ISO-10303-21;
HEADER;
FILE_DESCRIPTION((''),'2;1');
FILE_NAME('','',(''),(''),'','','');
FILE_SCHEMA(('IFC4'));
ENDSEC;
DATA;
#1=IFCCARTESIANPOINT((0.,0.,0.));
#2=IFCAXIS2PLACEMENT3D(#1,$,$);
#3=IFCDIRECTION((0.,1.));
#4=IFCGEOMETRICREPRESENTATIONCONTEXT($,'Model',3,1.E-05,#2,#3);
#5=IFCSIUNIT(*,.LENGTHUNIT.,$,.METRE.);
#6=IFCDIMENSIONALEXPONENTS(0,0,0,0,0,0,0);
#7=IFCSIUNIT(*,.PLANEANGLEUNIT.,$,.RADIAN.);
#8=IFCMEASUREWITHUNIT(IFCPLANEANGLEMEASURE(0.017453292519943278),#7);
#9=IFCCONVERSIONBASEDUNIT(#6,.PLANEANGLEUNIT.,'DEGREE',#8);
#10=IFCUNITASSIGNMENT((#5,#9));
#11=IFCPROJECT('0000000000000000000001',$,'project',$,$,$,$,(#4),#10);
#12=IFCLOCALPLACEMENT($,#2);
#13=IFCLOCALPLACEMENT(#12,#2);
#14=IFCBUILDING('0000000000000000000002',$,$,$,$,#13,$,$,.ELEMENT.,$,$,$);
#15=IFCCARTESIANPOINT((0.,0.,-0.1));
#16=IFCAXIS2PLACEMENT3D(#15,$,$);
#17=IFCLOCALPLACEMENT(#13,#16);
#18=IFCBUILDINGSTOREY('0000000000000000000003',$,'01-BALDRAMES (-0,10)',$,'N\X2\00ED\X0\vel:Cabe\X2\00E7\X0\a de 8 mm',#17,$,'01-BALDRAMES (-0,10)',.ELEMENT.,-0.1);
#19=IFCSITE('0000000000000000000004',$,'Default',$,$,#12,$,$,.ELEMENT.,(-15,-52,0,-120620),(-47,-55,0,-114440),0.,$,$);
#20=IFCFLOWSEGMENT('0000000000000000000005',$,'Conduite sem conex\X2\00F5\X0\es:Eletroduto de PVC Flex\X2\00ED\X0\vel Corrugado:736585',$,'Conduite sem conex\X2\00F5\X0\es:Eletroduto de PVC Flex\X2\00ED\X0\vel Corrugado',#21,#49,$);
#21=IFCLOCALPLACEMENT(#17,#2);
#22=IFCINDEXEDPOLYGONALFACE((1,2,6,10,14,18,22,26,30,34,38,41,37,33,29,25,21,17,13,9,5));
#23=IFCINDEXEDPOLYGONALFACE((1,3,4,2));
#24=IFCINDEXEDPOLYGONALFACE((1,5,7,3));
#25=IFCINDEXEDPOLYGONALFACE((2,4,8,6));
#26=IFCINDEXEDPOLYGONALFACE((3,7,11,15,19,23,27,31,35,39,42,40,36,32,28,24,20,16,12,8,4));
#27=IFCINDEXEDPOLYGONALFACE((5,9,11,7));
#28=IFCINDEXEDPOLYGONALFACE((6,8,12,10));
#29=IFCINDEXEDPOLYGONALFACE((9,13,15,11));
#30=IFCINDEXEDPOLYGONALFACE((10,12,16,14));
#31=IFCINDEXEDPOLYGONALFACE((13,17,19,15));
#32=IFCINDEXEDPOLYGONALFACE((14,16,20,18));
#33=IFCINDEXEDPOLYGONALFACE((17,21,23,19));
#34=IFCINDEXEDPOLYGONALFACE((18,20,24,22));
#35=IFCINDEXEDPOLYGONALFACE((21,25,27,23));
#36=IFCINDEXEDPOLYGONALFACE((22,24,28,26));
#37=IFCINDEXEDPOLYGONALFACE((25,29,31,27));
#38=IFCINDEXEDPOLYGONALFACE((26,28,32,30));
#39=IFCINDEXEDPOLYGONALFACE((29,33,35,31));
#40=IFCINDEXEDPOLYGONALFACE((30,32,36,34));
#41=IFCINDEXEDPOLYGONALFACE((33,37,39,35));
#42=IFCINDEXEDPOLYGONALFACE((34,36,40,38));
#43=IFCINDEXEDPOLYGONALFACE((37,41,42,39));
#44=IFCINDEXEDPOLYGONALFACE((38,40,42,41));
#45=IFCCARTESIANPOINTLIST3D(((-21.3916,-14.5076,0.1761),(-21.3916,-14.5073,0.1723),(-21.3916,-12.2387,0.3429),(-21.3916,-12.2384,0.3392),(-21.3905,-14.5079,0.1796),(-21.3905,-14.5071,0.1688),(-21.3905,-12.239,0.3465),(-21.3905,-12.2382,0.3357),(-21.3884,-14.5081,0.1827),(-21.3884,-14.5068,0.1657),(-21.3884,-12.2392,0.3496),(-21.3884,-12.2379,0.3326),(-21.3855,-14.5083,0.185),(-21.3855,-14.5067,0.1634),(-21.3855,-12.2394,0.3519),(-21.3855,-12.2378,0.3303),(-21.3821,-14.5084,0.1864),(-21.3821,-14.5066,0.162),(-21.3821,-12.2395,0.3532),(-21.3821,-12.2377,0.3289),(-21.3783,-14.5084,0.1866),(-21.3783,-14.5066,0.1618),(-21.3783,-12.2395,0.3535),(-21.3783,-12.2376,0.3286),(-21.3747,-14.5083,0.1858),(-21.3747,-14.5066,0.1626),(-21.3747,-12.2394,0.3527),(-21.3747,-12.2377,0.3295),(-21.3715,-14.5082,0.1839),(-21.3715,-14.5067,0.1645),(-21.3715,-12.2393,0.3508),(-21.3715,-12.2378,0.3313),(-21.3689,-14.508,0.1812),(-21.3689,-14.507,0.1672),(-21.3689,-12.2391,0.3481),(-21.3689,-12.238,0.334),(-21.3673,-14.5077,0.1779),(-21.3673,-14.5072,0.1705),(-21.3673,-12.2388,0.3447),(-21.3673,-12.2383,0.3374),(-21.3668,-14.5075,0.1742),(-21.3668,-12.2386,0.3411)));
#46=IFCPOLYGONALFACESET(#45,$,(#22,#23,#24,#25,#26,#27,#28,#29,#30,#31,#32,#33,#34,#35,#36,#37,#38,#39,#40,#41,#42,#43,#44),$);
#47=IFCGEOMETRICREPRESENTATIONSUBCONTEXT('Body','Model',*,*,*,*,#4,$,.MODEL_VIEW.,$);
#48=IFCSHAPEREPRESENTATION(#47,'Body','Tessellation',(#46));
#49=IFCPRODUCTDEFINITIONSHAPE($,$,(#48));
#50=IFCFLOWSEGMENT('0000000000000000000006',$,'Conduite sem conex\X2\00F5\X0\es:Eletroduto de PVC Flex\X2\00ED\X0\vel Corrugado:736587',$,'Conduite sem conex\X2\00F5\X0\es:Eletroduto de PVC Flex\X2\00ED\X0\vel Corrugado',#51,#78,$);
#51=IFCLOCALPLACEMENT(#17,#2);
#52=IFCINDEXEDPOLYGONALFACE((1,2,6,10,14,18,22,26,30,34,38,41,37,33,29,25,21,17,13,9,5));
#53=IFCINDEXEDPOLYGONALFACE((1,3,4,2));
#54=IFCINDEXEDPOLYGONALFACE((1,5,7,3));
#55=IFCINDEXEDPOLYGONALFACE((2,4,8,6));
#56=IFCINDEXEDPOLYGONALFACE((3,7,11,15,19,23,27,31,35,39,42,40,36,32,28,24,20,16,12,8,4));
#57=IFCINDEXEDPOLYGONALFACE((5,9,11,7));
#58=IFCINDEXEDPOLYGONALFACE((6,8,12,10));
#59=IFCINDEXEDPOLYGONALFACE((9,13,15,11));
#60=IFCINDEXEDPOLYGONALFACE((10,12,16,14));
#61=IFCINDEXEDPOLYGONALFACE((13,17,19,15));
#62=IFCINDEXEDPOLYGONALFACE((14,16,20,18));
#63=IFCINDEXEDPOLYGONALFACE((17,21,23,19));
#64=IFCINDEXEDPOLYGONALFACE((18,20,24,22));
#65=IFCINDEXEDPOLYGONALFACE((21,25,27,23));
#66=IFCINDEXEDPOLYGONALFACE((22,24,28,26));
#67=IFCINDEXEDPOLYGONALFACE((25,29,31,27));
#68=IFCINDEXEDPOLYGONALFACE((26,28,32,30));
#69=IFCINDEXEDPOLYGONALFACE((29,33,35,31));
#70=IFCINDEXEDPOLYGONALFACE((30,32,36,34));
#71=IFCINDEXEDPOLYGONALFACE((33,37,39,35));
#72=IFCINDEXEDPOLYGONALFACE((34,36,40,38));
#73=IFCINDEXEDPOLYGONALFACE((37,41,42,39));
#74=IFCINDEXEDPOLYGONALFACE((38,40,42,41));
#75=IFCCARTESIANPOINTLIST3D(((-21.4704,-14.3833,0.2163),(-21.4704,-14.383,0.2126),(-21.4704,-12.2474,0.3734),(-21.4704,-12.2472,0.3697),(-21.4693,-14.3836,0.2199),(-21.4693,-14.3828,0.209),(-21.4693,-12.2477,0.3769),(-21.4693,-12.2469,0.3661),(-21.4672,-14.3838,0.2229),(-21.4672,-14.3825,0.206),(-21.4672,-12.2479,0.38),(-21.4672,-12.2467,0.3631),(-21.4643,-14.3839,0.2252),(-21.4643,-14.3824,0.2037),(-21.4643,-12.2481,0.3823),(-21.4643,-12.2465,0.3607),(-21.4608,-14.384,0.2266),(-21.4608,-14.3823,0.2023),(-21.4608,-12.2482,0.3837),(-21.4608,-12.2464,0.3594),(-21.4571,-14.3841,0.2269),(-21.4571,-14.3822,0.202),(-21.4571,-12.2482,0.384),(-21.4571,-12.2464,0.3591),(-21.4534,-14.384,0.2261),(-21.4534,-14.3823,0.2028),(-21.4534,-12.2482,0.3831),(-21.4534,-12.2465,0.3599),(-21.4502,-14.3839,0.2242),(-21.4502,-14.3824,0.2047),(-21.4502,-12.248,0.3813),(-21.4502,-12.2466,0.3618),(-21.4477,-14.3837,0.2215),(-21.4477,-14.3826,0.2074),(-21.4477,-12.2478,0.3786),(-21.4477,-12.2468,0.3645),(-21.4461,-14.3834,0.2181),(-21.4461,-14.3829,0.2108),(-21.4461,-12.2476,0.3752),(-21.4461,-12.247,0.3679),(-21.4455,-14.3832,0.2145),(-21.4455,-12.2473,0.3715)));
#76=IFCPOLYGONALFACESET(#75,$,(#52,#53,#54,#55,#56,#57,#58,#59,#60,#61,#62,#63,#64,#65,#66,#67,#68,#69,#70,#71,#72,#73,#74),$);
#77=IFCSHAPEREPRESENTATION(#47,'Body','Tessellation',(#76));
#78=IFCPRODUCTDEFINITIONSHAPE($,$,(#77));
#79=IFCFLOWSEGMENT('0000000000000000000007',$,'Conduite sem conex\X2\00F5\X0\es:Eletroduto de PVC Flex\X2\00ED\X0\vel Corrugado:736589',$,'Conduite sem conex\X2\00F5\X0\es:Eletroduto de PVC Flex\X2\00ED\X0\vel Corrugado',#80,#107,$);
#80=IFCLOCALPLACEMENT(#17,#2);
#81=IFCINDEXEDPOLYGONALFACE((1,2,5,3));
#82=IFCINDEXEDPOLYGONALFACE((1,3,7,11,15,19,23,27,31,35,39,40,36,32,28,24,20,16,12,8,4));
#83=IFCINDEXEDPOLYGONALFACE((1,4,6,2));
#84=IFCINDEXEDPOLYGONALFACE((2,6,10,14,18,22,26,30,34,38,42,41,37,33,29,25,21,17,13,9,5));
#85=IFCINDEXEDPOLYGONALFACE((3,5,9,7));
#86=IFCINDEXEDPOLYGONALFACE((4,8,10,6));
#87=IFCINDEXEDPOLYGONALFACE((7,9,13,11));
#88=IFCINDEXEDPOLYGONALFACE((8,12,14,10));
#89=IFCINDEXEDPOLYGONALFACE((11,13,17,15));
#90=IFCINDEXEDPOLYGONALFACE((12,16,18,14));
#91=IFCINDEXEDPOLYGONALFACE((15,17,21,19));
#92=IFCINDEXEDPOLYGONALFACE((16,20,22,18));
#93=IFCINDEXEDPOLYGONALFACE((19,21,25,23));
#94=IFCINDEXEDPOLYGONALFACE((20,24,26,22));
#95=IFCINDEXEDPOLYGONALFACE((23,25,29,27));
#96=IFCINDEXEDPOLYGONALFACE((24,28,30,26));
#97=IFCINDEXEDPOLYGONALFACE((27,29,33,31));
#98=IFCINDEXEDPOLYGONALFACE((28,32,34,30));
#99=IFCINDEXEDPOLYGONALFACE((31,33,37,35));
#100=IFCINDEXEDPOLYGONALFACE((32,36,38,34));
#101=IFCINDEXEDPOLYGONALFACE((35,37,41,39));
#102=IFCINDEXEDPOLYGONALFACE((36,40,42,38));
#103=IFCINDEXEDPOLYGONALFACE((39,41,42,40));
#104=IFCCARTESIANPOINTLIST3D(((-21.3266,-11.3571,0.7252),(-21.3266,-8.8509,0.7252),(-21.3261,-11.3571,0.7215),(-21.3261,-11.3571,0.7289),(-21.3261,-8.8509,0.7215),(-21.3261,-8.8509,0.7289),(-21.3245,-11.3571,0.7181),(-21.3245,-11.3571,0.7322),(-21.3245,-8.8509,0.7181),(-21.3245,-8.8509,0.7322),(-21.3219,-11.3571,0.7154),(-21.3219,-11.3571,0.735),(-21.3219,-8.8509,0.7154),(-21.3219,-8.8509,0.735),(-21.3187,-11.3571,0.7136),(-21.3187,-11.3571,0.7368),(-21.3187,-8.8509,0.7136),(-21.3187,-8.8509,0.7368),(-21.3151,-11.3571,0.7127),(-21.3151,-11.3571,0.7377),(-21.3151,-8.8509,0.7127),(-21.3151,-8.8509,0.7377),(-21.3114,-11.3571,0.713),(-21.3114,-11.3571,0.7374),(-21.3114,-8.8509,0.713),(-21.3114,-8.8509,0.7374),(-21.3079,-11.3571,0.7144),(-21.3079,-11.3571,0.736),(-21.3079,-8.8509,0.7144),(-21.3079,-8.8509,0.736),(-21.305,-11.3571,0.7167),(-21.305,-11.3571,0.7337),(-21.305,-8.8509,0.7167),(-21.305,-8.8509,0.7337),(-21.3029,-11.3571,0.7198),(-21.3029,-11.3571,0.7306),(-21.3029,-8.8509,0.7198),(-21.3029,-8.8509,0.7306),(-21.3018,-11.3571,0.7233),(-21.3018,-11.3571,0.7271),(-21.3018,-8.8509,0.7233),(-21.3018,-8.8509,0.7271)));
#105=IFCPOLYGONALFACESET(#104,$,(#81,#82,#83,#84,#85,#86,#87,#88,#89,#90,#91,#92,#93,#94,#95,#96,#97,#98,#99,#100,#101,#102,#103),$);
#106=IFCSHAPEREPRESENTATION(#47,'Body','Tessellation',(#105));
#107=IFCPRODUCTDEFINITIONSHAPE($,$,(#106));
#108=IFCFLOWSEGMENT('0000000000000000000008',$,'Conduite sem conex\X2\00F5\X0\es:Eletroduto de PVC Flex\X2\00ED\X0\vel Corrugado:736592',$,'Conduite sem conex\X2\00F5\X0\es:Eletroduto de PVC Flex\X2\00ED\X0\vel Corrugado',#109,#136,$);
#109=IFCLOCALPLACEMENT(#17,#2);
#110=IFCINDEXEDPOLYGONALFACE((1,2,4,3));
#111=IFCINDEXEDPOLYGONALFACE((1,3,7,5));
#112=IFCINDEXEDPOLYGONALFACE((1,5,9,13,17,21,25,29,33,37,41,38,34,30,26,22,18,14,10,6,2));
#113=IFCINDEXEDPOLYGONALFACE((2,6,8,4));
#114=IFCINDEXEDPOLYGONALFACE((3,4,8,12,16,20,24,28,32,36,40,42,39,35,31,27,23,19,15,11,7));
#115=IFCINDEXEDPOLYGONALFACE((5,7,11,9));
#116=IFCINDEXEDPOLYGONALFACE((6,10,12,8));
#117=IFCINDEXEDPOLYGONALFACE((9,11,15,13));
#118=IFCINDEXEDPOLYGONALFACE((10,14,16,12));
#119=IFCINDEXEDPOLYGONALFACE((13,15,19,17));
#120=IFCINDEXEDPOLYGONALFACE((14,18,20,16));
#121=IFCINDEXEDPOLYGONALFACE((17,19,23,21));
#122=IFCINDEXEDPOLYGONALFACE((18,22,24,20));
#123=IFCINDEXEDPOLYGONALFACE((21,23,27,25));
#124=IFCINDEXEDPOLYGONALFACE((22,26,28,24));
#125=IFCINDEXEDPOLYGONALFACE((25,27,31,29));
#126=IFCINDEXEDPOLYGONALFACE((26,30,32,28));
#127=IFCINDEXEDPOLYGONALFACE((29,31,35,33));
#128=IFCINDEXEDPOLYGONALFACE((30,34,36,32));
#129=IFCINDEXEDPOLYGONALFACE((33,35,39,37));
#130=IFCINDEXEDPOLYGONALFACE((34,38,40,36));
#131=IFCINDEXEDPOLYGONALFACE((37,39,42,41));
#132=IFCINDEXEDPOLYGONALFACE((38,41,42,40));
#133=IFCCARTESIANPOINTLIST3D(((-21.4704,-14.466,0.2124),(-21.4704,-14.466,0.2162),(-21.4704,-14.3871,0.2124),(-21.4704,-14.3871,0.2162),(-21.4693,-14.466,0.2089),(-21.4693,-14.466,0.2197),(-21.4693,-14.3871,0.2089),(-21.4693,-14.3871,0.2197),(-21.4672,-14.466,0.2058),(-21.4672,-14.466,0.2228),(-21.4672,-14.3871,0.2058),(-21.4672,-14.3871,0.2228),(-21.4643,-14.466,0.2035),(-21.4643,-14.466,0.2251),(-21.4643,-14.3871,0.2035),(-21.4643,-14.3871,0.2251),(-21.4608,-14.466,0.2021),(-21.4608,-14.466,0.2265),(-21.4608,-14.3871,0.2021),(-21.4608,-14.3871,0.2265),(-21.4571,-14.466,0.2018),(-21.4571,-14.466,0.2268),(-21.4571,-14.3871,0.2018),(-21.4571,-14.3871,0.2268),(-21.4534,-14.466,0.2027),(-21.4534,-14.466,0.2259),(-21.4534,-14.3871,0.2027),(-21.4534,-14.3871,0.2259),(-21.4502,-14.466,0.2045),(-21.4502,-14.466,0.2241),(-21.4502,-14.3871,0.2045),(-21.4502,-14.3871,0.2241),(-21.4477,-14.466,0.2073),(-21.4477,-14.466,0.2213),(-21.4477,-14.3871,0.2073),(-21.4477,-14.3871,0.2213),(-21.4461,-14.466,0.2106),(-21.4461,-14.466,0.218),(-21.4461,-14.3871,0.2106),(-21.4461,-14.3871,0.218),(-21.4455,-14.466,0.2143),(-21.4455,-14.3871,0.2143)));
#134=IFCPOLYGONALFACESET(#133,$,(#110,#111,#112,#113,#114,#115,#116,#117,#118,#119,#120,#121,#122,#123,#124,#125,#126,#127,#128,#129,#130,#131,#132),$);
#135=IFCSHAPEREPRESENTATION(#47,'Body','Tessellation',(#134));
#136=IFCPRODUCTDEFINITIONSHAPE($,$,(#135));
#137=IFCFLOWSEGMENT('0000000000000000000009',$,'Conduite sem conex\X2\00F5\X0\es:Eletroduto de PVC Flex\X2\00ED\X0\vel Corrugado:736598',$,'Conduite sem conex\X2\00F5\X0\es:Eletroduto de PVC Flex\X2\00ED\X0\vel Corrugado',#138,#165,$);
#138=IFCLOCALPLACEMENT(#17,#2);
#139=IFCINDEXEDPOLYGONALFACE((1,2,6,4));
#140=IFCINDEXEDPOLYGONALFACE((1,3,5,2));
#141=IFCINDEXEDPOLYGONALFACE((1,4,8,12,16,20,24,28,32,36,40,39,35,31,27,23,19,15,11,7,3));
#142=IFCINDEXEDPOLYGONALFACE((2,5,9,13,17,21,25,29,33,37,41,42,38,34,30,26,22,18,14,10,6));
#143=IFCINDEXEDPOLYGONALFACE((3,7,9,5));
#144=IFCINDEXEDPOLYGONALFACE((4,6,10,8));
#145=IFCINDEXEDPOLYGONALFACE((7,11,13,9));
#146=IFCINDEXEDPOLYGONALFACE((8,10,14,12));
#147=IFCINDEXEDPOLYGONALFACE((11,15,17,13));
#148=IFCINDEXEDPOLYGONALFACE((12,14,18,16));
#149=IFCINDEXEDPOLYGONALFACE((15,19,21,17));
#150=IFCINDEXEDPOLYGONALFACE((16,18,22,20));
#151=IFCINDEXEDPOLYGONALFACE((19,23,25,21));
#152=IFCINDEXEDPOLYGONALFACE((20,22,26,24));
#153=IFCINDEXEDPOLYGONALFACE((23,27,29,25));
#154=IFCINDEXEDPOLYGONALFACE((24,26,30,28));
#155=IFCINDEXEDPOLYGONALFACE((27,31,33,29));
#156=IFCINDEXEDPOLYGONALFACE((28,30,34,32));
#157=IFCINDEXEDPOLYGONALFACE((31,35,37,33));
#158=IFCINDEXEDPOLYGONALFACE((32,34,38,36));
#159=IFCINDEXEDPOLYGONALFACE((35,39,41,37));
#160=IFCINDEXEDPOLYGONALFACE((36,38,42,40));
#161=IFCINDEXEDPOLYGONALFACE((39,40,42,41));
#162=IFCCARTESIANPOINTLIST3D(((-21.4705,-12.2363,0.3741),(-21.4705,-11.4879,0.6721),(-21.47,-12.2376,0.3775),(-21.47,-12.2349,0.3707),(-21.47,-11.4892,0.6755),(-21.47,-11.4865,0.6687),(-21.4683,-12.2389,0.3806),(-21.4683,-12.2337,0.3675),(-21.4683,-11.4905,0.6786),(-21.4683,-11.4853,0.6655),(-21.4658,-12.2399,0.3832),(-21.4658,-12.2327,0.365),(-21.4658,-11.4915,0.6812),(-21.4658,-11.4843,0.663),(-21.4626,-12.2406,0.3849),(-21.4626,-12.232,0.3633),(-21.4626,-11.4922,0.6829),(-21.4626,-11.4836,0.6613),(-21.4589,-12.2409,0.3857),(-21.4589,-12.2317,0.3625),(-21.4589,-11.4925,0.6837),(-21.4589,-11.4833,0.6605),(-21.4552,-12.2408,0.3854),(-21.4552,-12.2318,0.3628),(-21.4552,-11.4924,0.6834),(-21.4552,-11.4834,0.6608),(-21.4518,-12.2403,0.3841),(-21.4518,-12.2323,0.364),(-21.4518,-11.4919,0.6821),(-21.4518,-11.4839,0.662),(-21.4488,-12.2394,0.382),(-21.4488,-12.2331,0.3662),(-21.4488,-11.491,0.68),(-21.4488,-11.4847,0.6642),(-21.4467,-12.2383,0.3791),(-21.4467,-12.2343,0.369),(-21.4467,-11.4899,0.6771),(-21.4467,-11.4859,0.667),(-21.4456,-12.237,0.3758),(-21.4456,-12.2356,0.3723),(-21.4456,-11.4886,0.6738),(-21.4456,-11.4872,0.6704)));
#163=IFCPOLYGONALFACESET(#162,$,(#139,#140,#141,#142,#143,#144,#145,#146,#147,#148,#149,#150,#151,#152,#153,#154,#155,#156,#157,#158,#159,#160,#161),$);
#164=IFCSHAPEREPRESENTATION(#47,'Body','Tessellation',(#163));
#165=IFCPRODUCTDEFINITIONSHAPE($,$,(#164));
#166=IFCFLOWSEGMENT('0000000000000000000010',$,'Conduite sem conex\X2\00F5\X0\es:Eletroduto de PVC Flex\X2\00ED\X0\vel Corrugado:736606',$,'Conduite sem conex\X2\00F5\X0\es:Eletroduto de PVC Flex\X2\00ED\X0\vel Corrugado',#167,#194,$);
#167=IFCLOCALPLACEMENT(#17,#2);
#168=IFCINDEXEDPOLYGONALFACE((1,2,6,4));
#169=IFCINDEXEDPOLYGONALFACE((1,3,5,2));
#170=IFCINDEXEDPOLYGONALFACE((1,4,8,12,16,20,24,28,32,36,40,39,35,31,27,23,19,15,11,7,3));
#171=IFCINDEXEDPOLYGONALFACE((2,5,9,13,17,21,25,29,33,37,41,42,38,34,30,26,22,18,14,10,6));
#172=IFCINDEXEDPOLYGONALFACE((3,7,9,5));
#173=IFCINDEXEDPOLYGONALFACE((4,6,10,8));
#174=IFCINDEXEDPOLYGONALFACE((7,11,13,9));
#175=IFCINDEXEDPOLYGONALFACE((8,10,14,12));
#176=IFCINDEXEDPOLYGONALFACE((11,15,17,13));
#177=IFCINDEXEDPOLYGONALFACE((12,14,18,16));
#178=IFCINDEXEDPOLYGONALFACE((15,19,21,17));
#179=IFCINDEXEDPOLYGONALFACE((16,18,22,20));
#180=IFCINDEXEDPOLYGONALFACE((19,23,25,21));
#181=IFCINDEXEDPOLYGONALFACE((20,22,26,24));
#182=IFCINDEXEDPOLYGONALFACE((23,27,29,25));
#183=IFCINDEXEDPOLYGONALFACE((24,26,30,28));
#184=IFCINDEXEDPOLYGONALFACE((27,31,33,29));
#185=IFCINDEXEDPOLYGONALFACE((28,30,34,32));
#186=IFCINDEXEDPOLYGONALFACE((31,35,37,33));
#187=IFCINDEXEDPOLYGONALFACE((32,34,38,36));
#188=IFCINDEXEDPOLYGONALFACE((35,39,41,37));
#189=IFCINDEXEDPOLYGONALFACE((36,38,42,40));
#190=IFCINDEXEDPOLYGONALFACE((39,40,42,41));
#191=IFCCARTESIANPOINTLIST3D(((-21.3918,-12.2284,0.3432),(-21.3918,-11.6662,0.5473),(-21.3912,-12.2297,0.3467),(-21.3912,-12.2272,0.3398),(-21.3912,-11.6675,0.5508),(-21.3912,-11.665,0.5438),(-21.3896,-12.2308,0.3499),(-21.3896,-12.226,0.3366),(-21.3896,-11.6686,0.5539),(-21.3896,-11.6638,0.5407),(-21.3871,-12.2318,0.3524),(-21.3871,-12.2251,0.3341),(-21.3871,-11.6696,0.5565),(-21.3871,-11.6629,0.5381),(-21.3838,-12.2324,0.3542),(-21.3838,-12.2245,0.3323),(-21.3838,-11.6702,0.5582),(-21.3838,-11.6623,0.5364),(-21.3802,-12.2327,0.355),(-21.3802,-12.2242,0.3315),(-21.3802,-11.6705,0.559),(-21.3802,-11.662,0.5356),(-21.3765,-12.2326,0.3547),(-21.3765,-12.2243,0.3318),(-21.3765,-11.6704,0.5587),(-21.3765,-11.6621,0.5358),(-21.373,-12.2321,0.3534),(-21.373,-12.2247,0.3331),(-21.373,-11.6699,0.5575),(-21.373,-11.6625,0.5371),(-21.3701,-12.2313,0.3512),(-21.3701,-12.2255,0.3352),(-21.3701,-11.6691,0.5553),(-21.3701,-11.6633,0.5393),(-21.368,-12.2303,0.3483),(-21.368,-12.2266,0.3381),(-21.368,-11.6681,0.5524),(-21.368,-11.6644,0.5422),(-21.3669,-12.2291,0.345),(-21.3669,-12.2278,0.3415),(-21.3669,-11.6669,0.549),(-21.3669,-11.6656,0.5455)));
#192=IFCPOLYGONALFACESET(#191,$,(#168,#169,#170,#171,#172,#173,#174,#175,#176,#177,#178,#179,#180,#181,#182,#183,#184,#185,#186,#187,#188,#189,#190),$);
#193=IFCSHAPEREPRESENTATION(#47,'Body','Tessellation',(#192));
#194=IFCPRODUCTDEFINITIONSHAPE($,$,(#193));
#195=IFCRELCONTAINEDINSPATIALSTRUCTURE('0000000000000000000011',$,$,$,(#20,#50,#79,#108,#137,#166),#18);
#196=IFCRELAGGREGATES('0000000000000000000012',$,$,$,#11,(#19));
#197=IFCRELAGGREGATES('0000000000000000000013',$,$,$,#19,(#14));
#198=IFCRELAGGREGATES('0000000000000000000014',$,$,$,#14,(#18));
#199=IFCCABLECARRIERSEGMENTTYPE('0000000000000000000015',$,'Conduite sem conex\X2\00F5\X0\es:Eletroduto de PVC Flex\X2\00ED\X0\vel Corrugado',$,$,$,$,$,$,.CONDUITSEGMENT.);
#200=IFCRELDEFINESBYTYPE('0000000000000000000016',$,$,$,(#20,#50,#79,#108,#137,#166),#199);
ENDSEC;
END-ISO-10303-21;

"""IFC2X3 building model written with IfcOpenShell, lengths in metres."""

from ifc_helpers import new_model, entity, si_unit, converted_unit, direction, frame, frame_2d, origin, place, context, subcontext, project, spatial, circle, extrude, type_object, element, save


model = new_model("IFC2X3")

# Units and contexts
model_context = context("Model", 3, precision=1e-05, world=origin(), true_north=direction((0.0, 1.0)))
body_context = subcontext(model_context, "Body", "Model", "MODEL_VIEW")
ifc_project = project(units=[si_unit("LENGTHUNIT", "METRE"), converted_unit("PLANEANGLEUNIT", "DEGREE", entity("IfcPlaneAngleMeasure", 0.017453292519943278), si_unit("PLANEANGLEUNIT", "RADIAN"), dimensions=[0, 0, 0, 0, 0, 0, 0])], contexts=[model_context])

# Site, building, storey
site_placement = place(None, origin())
site = spatial("IfcSite", under=ifc_project, at=site_placement, Name="Default", CompositionType="ELEMENT", RefLatitude=(-15, -52, 0, -120620), RefLongitude=(-47, -55, 0, -114440), RefElevation=0.0)
building_placement = place(site_placement, origin())
building = spatial("IfcBuilding", under=site, at=building_placement, CompositionType="ELEMENT")
storey_placement = place(building_placement, frame((0.0, 0.0, -0.1)))
storey = spatial("IfcBuildingStorey", under=building, at=storey_placement, Name="01-BALDRAMES (-0,10)", ObjectType="Nível:Cabeça de 8 mm", LongName="01-BALDRAMES (-0,10)", CompositionType="ELEMENT", Elevation=-0.1)

# Flow segments
cable_carrier_segment_type = type_object("IfcCableCarrierSegmentType", Name="Conduite sem conexões:Eletroduto de PVC Flexível Corrugado", PredefinedType="CONDUITSEGMENT")
flow_segment_1_placement = place(storey_placement, origin())
element("IfcFlowSegment", 1, at=flow_segment_1_placement, inside=storey, type_object=cable_carrier_segment_type, Name="Conduite sem conexões:Eletroduto de PVC Flexível Corrugado:736585", ObjectType="Conduite sem conexões:Eletroduto de PVC Flexível Corrugado", context=body_context, shape_type="SweptSolid", body=[
    extrude(circle(Radius=0.0125, at=frame_2d((0.0, 0.0), x_axis=(1.0, 0.0))), frame((-21.3793, -14.5075, 0.1742), z_axis=(0.0, 0.997306, 0.073349), x_axis=(1.0, 0.0, 0.0)), (0.0, 0.0, 1.0), 2.275),
])
flow_segment_2_placement = place(storey_placement, origin())
element("IfcFlowSegment", 2, at=flow_segment_2_placement, inside=storey, type_object=cable_carrier_segment_type, Name="Conduite sem conexões:Eletroduto de PVC Flexível Corrugado:736587", ObjectType="Conduite sem conexões:Eletroduto de PVC Flexível Corrugado", context=body_context, shape_type="SweptSolid", body=[
    extrude(circle(Radius=0.0125, at=frame_2d((0.0, 0.0), x_axis=(1.0, 0.0))), frame((-21.458, -14.3832, 0.2145), z_axis=(0.0, 0.997306, 0.073349), x_axis=(1.0, 0.0, 0.0)), (0.0, 0.0, 1.0), 2.1416),
])
flow_segment_3_placement = place(storey_placement, origin())
element("IfcFlowSegment", 3, at=flow_segment_3_placement, inside=storey, type_object=cable_carrier_segment_type, Name="Conduite sem conexões:Eletroduto de PVC Flexível Corrugado:736589", ObjectType="Conduite sem conexões:Eletroduto de PVC Flexível Corrugado", context=body_context, shape_type="SweptSolid", body=[
    extrude(circle(Radius=0.0125, at=frame_2d((0.0, 0.0), x_axis=(1.0, 0.0))), frame((-21.3141, -11.3571, 0.7252), z_axis=(0.0, 1.0, 0.0), x_axis=(-1.0, 0.0, 0.0)), (0.0, 0.0, 1.0), 2.5062),
])
flow_segment_4_placement = place(storey_placement, origin())
element("IfcFlowSegment", 4, at=flow_segment_4_placement, inside=storey, type_object=cable_carrier_segment_type, Name="Conduite sem conexões:Eletroduto de PVC Flexível Corrugado:736592", ObjectType="Conduite sem conexões:Eletroduto de PVC Flexível Corrugado", context=body_context, shape_type="SweptSolid", body=[
    extrude(circle(Radius=0.0125, at=frame_2d((0.0, 0.0), x_axis=(1.0, 0.0))), frame((-21.458, -14.466, 0.2143), z_axis=(0.0, 1.0, 0.0), x_axis=(1.0, 0.0, 0.0)), (0.0, 0.0, 1.0), 0.0789),
])
flow_segment_5_placement = place(storey_placement, origin())
element("IfcFlowSegment", 5, at=flow_segment_5_placement, inside=storey, type_object=cable_carrier_segment_type, Name="Conduite sem conexões:Eletroduto de PVC Flexível Corrugado:736598", ObjectType="Conduite sem conexões:Eletroduto de PVC Flexível Corrugado", context=body_context, shape_type="SweptSolid", body=[
    extrude(circle(Radius=0.0125, at=frame_2d((0.0, 0.0), x_axis=(1.0, 0.0))), frame((-21.458, -12.2363, 0.3741), z_axis=(0.0, 0.929054, 0.369943), x_axis=(-1.0, 0.0, 0.0)), (0.0, 0.0, 1.0), 0.8055),
])
flow_segment_6_placement = place(storey_placement, origin())
element("IfcFlowSegment", 6, at=flow_segment_6_placement, inside=storey, type_object=cable_carrier_segment_type, Name="Conduite sem conexões:Eletroduto de PVC Flexível Corrugado:736606", ObjectType="Conduite sem conexões:Eletroduto de PVC Flexível Corrugado", context=body_context, shape_type="SweptSolid", body=[
    extrude(circle(Radius=0.0125, at=frame_2d((0.0, 0.0), x_axis=(1.0, 0.0))), frame((-21.3793, -12.2284, 0.3432), z_axis=(0.0, 0.94, 0.341175), x_axis=(-1.0, 0.0, 0.0)), (0.0, 0.0, 1.0), 0.5981),
])

save(model, "model.ifc")
